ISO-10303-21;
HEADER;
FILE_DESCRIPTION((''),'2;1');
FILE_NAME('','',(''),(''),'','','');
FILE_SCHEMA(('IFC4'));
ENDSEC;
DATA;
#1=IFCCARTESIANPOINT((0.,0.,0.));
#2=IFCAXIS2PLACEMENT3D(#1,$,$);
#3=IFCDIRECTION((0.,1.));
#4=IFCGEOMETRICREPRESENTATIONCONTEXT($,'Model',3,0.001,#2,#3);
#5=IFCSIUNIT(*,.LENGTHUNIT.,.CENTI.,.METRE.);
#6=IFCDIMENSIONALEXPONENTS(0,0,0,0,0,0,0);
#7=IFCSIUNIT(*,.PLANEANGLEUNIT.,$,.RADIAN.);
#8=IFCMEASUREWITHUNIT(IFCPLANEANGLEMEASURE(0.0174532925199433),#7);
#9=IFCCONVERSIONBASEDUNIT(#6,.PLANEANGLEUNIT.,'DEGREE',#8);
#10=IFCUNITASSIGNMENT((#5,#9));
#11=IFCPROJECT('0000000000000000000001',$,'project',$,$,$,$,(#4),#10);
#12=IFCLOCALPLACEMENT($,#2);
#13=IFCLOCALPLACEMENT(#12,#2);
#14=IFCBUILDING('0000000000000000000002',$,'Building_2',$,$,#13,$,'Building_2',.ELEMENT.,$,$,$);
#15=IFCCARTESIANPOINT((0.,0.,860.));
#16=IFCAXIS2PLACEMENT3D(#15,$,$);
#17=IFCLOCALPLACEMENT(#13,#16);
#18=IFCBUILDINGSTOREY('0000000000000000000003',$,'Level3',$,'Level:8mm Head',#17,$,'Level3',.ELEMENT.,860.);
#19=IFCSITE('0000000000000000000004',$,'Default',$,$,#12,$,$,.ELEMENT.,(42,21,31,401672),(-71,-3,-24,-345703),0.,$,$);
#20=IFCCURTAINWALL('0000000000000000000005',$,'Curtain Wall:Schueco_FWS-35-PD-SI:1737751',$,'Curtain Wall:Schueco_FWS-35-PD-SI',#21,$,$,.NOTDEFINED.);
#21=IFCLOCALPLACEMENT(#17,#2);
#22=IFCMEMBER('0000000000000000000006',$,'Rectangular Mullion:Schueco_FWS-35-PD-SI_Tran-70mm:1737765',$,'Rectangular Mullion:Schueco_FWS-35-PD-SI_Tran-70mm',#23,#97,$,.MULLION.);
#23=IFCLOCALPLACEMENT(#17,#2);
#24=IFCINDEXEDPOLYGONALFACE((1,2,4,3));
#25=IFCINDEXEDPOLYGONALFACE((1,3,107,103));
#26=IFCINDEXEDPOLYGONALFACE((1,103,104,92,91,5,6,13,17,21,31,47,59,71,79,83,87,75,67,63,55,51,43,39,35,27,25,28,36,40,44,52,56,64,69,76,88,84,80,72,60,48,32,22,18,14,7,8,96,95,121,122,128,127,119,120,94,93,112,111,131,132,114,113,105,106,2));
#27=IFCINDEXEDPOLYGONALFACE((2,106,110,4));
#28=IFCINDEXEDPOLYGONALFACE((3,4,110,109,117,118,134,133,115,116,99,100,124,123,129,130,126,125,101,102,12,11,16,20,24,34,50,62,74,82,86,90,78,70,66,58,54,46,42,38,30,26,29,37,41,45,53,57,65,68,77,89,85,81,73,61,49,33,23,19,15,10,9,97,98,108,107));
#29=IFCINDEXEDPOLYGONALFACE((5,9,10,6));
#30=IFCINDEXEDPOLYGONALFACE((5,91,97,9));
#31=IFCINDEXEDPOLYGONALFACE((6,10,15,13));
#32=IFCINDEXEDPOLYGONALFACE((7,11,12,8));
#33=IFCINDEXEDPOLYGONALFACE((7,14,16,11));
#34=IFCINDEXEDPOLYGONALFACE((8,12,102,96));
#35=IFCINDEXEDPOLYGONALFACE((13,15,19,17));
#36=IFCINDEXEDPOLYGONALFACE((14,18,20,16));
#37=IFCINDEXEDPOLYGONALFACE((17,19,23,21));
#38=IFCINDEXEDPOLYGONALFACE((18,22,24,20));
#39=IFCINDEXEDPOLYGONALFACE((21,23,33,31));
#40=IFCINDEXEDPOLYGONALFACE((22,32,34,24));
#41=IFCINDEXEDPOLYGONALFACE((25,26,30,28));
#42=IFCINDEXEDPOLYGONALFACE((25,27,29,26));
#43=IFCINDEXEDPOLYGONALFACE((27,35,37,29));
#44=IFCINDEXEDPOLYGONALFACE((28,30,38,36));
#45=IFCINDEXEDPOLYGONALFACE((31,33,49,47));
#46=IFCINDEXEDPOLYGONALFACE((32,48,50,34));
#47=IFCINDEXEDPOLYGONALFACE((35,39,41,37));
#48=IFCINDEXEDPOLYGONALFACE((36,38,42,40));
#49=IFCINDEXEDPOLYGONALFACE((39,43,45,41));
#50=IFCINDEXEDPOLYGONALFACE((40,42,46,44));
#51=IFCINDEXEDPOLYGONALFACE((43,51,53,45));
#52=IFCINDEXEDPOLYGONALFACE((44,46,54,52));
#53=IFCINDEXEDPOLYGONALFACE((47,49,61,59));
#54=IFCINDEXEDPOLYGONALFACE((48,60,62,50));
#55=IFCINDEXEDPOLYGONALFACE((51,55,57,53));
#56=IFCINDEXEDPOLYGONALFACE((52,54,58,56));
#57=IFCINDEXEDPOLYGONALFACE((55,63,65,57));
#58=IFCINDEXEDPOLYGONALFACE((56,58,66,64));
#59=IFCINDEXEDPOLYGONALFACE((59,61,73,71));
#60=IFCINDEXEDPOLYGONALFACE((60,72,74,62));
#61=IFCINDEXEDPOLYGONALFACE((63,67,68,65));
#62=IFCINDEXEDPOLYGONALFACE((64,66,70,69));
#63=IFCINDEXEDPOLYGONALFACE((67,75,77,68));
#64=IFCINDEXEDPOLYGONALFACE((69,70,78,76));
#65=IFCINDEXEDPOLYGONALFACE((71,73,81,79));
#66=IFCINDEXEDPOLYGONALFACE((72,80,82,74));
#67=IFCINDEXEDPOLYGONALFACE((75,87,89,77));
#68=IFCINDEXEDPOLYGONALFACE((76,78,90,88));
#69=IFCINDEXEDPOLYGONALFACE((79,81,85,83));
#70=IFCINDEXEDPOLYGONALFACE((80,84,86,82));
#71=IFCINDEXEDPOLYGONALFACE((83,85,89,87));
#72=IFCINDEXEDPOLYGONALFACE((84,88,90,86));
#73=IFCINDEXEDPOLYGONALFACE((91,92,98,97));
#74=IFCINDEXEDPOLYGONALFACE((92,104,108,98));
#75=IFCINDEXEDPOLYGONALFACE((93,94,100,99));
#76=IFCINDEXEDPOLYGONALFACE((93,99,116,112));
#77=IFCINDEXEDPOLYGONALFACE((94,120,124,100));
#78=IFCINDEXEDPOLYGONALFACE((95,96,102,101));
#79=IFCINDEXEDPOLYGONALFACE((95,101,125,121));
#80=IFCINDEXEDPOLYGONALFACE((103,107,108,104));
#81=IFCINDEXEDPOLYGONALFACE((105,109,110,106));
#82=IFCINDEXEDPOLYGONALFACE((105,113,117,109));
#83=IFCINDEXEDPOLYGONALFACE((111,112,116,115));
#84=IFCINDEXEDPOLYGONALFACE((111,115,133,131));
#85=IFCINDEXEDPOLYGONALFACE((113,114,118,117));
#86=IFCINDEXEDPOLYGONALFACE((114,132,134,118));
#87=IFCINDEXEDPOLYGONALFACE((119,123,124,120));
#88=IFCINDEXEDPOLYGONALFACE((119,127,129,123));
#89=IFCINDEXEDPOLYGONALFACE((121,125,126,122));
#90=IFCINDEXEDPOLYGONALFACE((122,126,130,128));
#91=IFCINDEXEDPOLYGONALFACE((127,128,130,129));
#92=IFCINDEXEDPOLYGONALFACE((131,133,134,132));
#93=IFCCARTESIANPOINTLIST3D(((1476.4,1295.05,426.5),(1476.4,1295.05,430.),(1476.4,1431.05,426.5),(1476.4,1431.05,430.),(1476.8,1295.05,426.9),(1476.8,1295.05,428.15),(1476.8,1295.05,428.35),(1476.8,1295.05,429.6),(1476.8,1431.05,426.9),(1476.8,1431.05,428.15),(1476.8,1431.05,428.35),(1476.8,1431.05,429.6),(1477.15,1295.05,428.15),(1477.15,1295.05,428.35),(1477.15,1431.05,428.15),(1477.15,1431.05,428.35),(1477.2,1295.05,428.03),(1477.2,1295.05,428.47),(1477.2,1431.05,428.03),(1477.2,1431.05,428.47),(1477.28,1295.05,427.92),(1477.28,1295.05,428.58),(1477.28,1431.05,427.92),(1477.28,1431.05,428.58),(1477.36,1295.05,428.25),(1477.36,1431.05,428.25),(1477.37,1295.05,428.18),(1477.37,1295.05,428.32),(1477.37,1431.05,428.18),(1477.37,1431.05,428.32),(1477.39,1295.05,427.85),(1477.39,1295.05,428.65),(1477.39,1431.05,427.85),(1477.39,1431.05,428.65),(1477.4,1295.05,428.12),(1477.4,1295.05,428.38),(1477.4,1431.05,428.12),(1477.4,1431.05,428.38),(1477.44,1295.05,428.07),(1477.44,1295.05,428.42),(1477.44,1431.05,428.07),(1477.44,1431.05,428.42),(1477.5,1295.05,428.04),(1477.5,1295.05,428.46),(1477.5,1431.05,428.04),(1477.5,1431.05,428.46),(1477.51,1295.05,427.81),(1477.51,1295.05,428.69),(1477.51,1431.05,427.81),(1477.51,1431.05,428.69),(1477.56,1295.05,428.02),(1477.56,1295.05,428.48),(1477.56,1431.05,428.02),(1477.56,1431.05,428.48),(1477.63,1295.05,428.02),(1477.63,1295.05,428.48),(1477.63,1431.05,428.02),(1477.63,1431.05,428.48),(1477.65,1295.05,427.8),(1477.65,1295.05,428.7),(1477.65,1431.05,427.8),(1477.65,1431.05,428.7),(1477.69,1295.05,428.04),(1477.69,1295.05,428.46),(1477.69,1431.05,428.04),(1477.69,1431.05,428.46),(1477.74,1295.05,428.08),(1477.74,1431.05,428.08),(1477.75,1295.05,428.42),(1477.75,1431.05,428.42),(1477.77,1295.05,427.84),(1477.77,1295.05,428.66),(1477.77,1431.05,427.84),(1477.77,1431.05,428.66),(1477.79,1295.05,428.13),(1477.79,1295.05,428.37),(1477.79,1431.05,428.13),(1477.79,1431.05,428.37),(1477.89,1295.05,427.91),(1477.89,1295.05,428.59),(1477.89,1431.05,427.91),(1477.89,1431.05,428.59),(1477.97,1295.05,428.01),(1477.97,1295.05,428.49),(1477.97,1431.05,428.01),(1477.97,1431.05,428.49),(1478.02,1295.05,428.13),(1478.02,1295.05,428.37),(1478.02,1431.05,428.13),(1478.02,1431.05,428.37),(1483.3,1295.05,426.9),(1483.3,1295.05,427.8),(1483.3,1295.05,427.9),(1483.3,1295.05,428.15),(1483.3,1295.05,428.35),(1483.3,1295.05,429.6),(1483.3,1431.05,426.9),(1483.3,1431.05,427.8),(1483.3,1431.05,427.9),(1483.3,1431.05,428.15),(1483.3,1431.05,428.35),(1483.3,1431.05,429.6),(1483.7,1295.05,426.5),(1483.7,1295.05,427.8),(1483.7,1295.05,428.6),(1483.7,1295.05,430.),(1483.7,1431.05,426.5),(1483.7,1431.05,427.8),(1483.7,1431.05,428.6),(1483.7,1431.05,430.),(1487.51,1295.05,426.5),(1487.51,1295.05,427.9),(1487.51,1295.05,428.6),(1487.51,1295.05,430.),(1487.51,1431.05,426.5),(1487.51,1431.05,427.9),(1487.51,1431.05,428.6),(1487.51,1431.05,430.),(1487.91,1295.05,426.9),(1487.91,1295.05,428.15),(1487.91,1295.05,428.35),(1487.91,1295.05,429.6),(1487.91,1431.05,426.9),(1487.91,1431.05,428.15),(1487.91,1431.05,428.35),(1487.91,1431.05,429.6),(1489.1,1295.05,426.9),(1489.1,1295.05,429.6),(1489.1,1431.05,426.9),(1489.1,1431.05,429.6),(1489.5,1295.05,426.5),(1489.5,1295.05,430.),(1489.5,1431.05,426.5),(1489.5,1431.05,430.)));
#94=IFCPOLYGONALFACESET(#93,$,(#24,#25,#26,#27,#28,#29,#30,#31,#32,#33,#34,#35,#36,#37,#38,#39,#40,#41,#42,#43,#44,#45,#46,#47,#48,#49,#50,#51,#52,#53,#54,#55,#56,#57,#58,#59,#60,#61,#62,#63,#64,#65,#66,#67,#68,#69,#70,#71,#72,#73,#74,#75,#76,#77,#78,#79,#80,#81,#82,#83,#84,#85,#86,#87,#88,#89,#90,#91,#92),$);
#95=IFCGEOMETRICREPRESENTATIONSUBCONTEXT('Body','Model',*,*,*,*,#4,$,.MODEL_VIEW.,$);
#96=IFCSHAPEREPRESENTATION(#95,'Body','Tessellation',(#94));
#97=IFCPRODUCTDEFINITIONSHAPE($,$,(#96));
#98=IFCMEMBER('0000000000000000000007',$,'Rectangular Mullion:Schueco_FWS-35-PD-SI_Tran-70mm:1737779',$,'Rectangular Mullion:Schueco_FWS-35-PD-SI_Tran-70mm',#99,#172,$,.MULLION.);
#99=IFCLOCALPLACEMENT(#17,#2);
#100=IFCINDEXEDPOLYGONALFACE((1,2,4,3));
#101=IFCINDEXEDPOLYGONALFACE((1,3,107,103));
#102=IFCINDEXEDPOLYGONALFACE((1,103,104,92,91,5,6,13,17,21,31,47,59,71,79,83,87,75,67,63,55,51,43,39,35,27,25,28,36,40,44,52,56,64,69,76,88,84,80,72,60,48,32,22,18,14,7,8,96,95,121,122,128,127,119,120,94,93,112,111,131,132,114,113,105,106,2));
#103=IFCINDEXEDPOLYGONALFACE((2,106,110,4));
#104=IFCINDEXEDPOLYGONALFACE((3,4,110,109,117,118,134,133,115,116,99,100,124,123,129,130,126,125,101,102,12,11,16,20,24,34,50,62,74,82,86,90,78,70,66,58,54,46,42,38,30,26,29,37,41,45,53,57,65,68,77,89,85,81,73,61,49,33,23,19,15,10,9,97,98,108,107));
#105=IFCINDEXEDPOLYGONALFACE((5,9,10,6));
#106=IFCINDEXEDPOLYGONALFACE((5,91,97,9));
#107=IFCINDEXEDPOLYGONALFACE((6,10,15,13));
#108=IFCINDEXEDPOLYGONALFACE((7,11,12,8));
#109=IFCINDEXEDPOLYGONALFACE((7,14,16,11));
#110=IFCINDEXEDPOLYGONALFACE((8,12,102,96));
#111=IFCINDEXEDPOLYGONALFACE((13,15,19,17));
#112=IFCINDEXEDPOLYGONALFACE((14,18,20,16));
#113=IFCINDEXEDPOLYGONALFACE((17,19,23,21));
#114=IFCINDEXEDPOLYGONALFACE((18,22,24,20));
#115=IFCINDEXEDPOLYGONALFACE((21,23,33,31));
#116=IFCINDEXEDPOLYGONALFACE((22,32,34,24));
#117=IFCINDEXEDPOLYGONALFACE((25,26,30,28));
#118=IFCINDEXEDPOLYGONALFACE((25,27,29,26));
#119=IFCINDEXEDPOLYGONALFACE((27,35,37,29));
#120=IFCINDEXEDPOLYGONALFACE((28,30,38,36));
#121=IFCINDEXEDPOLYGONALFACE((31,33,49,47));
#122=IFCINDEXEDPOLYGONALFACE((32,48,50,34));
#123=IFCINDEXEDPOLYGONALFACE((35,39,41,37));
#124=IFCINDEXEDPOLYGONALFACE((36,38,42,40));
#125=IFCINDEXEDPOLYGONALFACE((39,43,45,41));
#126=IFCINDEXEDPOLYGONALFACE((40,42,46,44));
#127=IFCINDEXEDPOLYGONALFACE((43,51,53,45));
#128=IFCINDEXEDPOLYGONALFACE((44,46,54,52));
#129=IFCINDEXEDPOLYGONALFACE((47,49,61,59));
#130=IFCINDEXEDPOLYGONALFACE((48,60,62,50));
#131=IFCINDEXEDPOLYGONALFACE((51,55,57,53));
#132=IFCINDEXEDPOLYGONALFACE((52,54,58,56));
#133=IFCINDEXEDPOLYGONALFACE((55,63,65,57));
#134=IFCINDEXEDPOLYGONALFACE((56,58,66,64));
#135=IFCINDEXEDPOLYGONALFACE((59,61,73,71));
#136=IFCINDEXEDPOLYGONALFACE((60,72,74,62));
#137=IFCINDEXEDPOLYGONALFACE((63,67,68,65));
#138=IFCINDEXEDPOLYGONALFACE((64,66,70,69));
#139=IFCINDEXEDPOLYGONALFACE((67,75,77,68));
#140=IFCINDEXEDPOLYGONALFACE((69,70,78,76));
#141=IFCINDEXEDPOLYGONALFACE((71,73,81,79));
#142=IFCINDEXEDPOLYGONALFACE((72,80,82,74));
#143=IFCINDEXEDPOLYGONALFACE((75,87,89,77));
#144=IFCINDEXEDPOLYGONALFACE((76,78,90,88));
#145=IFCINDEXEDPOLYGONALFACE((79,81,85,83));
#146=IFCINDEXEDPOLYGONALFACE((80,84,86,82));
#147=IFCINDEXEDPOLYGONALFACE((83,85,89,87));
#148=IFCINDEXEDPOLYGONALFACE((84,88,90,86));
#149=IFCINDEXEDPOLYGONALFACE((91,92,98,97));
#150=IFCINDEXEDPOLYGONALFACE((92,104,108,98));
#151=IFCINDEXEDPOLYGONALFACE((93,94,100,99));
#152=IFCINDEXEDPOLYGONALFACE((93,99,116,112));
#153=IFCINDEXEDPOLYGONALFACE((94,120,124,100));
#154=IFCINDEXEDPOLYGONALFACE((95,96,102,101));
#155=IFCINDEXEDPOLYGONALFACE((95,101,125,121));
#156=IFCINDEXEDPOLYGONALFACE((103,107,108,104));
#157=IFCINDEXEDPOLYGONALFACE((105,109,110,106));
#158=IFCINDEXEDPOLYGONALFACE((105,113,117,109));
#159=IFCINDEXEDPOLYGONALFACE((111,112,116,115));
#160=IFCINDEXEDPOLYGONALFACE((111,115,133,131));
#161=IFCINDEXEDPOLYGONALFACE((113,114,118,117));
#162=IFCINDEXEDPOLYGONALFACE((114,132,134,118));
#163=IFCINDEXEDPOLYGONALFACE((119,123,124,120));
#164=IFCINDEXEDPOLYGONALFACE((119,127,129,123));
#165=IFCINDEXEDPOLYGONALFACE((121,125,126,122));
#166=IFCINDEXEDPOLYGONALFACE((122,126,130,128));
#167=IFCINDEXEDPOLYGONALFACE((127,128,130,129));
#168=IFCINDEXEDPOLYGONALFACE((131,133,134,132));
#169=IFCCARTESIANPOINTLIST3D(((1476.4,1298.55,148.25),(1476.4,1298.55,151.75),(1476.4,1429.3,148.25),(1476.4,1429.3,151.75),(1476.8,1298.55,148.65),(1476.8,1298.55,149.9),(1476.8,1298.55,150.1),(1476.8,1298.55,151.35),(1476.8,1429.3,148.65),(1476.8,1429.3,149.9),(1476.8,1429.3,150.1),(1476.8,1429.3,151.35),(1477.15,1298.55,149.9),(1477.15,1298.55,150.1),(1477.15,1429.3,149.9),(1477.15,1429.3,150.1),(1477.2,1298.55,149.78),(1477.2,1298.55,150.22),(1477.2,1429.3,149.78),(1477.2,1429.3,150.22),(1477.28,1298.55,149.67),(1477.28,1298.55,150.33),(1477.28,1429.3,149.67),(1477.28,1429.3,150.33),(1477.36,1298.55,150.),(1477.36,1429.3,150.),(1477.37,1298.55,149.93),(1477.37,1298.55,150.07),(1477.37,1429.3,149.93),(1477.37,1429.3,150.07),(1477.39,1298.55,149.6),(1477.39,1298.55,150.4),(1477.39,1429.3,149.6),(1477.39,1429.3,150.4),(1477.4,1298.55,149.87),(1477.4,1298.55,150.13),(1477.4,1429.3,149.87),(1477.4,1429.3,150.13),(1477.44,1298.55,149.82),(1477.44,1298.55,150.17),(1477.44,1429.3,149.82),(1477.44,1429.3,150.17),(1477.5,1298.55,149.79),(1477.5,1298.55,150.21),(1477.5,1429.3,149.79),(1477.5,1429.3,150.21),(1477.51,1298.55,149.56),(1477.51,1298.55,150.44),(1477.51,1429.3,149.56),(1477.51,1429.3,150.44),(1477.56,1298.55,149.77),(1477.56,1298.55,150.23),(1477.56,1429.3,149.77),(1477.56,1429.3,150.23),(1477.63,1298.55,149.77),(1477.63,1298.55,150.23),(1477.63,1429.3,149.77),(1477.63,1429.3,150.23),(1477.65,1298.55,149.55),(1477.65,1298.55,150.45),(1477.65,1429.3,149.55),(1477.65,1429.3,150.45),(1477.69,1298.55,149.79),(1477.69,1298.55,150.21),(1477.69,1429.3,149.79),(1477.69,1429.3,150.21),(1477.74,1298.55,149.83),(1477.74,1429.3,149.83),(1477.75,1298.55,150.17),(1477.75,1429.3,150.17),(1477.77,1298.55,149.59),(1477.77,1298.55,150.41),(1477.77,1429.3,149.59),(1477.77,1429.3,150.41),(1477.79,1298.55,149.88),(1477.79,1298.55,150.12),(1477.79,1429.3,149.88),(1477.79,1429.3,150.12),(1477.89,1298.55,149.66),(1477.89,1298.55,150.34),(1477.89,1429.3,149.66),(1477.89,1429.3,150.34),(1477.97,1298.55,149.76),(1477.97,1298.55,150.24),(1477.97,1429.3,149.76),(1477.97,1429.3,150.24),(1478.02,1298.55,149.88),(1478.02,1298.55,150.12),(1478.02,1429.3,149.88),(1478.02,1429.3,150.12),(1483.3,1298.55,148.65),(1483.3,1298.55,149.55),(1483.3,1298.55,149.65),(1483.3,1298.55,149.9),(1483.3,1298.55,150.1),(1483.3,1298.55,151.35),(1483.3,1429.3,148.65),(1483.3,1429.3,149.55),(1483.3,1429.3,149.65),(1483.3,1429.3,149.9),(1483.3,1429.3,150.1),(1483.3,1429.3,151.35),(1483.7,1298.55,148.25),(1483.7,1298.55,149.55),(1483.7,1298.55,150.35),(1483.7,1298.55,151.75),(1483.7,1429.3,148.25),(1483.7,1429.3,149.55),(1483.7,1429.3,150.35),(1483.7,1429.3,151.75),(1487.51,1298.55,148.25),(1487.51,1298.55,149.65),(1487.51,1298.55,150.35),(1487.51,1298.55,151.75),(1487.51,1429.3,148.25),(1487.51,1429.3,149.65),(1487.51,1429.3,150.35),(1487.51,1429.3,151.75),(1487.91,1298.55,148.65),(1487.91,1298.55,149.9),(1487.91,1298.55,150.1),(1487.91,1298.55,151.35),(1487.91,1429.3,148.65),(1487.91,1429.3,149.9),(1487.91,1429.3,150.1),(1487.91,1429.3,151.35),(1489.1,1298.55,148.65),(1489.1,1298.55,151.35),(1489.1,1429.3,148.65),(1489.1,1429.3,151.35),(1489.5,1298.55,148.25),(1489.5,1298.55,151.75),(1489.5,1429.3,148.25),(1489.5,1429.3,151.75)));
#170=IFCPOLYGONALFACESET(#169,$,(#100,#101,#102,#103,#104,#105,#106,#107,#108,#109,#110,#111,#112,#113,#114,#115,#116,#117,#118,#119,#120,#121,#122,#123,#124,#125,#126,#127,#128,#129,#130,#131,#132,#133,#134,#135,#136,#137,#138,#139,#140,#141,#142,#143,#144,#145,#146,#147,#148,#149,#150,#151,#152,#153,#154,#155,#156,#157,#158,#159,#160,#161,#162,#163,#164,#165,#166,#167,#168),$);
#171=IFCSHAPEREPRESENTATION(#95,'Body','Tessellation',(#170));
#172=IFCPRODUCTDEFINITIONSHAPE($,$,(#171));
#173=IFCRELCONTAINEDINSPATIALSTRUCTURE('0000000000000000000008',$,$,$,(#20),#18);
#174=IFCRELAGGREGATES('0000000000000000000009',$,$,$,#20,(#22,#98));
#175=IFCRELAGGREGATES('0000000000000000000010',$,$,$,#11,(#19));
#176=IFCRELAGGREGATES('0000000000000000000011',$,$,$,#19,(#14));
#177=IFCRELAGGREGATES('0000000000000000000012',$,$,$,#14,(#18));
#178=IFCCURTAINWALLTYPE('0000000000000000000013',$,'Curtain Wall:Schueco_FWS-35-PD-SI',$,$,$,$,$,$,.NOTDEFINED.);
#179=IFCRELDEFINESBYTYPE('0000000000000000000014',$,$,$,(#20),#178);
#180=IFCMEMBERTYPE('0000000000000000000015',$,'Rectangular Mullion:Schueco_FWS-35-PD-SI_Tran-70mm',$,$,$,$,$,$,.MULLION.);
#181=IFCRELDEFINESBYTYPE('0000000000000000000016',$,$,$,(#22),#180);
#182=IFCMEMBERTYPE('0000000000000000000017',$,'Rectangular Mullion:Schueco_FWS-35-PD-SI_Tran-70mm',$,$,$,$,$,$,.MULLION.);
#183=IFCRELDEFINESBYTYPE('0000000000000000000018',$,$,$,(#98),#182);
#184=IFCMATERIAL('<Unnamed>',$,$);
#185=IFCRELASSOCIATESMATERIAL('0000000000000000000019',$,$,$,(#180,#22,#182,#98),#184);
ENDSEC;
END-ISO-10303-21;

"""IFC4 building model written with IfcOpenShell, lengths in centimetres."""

from ifc_helpers import new_model, entity, si_unit, converted_unit, direction, frame, origin, place, context, subcontext, project, spatial, line, arc, indexed_curve, outline, extrude, source, transform, mapped, material, type_object, type_shapes, element, aggregate, save


model = new_model("IFC4")

# Units and contexts
model_context = context("Model", 3, precision=0.001, world=origin(), true_north=direction((0.0, 1.0)))
body_context = subcontext(model_context, "Body", "Model", "MODEL_VIEW")
ifc_project = project(units=[si_unit("LENGTHUNIT", "METRE", prefix="CENTI"), converted_unit("PLANEANGLEUNIT", "DEGREE", entity("IfcPlaneAngleMeasure", 0.0174532925199433), si_unit("PLANEANGLEUNIT", "RADIAN"), dimensions=[0, 0, 0, 0, 0, 0, 0])], contexts=[model_context])

# Site, building, storey
site_placement = place(None, origin())
site = spatial("IfcSite", under=ifc_project, at=site_placement, Name="Default", CompositionType="ELEMENT", RefLatitude=(42, 21, 31, 401672), RefLongitude=(-71, -3, -24, -345703), RefElevation=0.0)
building_placement = place(site_placement, origin())
building = spatial("IfcBuilding", under=site, at=building_placement, Name="Building_2", LongName="Building_2", CompositionType="ELEMENT")
storey_placement = place(building_placement, frame((0.0, 0.0, 860.0)))
storey = spatial("IfcBuildingStorey", under=building, at=storey_placement, Name="Level3", ObjectType="Level:8mm Head", LongName="Level3", CompositionType="ELEMENT", Elevation=860.0)

# Curtain wall, members
curtain_wall_type = type_object("IfcCurtainWallType", Name="Curtain Wall:Schueco_FWS-35-PD-SI", PredefinedType="NOTDEFINED")
curtain_wall_placement = place(storey_placement, frame((0.0, 0.0, -860.0)))
curtain_wall = element("IfcCurtainWall", 1, at=curtain_wall_placement, inside=storey, type_object=curtain_wall_type, Name="Curtain Wall:Schueco_FWS-35-PD-SI:1737751", ObjectType="Curtain Wall:Schueco_FWS-35-PD-SI", PredefinedType="NOTDEFINED")
ifc_material_1 = material(Name="<Unnamed>")
member_type_1 = type_object("IfcMemberType", Name="Rectangular Mullion:Schueco_FWS-35-PD-SI_Tran-70mm", PredefinedType="MULLION", material=ifc_material_1)
shared_shape_1 = source(origin(), body_context, "Body", "SweptSolid", [
    extrude(outline(indexed_curve([(-1.78, -6.52), (1.72, -6.52), (1.72, 0.78), (0.42, 0.78), (0.42, 0.38), (1.32, 0.38), (1.32, -6.12), (0.07, -6.12), (0.07, -5.77), (0.42, -5.34), (0.09, -4.9), (0.09, -5.14), (-0.03, -5.56), (-0.15, -5.14), (-0.15, -4.9), (-0.48, -5.34), (-0.13, -5.77), (-0.13, -6.12), (-1.38, -6.12), (-1.38, 0.38), (-0.13, 0.38), (-0.13, 4.99), (-1.38, 4.99), (-1.38, 6.18), (1.32, 6.18), (1.32, 4.99), (0.07, 4.99), (0.07, 0.38), (0.32, 0.38), (0.32, 4.59), (1.72, 4.59), (1.72, 6.58), (-1.78, 6.58), (-1.78, 4.59), (-0.38, 4.59), (-0.38, 0.78), (-1.78, 0.78)], segments=[line(1, 2, 3, 4, 5, 6, 7, 8, 9), arc(9, 10, 11), line(11, 12), arc(12, 13, 14), line(14, 15), arc(15, 16, 17), line(17, 18, 19, 20, 21, 22, 23, 24, 25, 26, 27, 28, 29, 30, 31, 32, 33, 34, 35, 36, 37, 1)], self_intersect=False)), frame((-1.78, 4.58, -136.0), z_axis=(0.0, 0.0, 1.0), x_axis=(-1.0, 0.0, 0.0)), (0.0, 0.0, 1.0), 136.0),
])
type_shapes(member_type_1, [shared_shape_1])
member_1_placement = place(curtain_wall_placement, frame((1487.5, 1295.05, 1290.0), z_axis=(0.0, -1.0, 0.0), x_axis=(0.0, 0.0, 1.0)))
member_1 = element("IfcMember", 2, at=member_1_placement, type_object=member_type_1, material=ifc_material_1, Name="Rectangular Mullion:Schueco_FWS-35-PD-SI_Tran-70mm:1737765", ObjectType="Rectangular Mullion:Schueco_FWS-35-PD-SI_Tran-70mm", PredefinedType="MULLION", context=body_context, shape_type="MappedRepresentation", body=[
    mapped(shared_shape_1, transform((0.0, 0.0, 0.0), scale=1.0)),
])
member_type_2 = type_object("IfcMemberType", Name="Rectangular Mullion:Schueco_FWS-35-PD-SI_Tran-70mm", PredefinedType="MULLION", material=ifc_material_1)
shared_shape_2 = source(origin(), body_context, "Body", "SweptSolid", [
    extrude(outline(indexed_curve([(-1.78, -6.52), (1.72, -6.52), (1.72, 0.78), (0.42, 0.78), (0.42, 0.38), (1.32, 0.38), (1.32, -6.12), (0.07, -6.12), (0.07, -5.77), (0.42, -5.34), (0.09, -4.9), (0.09, -5.14), (-0.03, -5.56), (-0.15, -5.14), (-0.15, -4.9), (-0.48, -5.34), (-0.13, -5.77), (-0.13, -6.12), (-1.38, -6.12), (-1.38, 0.38), (-0.13, 0.38), (-0.13, 4.99), (-1.38, 4.99), (-1.38, 6.18), (1.32, 6.18), (1.32, 4.99), (0.07, 4.99), (0.07, 0.38), (0.32, 0.38), (0.32, 4.59), (1.72, 4.59), (1.72, 6.58), (-1.78, 6.58), (-1.78, 4.59), (-0.38, 4.59), (-0.38, 0.78), (-1.78, 0.78)], segments=[line(1, 2, 3, 4, 5, 6, 7, 8, 9), arc(9, 10, 11), line(11, 12), arc(12, 13, 14), line(14, 15), arc(15, 16, 17), line(17, 18, 19, 20, 21, 22, 23, 24, 25, 26, 27, 28, 29, 30, 31, 32, 33, 34, 35, 36, 37, 1)], self_intersect=False)), frame((-0.03, 4.58, -130.75), z_axis=(0.0, 0.0, 1.0), x_axis=(-1.0, 0.0, 0.0)), (0.0, 0.0, 1.0), 130.75),
])
type_shapes(member_type_2, [shared_shape_2])
member_2_placement = place(curtain_wall_placement, frame((1487.5, 1298.55, 1010.0), z_axis=(0.0, -1.0, 0.0), x_axis=(0.0, 0.0, 1.0)))
member_2 = element("IfcMember", 3, at=member_2_placement, type_object=member_type_2, material=ifc_material_1, Name="Rectangular Mullion:Schueco_FWS-35-PD-SI_Tran-70mm:1737779", ObjectType="Rectangular Mullion:Schueco_FWS-35-PD-SI_Tran-70mm", PredefinedType="MULLION", context=body_context, shape_type="MappedRepresentation", body=[
    mapped(shared_shape_2, transform((0.0, 0.0, 0.0), scale=1.0)),
])
aggregate(curtain_wall, [member_1, member_2])

save(model, "model.ifc")
